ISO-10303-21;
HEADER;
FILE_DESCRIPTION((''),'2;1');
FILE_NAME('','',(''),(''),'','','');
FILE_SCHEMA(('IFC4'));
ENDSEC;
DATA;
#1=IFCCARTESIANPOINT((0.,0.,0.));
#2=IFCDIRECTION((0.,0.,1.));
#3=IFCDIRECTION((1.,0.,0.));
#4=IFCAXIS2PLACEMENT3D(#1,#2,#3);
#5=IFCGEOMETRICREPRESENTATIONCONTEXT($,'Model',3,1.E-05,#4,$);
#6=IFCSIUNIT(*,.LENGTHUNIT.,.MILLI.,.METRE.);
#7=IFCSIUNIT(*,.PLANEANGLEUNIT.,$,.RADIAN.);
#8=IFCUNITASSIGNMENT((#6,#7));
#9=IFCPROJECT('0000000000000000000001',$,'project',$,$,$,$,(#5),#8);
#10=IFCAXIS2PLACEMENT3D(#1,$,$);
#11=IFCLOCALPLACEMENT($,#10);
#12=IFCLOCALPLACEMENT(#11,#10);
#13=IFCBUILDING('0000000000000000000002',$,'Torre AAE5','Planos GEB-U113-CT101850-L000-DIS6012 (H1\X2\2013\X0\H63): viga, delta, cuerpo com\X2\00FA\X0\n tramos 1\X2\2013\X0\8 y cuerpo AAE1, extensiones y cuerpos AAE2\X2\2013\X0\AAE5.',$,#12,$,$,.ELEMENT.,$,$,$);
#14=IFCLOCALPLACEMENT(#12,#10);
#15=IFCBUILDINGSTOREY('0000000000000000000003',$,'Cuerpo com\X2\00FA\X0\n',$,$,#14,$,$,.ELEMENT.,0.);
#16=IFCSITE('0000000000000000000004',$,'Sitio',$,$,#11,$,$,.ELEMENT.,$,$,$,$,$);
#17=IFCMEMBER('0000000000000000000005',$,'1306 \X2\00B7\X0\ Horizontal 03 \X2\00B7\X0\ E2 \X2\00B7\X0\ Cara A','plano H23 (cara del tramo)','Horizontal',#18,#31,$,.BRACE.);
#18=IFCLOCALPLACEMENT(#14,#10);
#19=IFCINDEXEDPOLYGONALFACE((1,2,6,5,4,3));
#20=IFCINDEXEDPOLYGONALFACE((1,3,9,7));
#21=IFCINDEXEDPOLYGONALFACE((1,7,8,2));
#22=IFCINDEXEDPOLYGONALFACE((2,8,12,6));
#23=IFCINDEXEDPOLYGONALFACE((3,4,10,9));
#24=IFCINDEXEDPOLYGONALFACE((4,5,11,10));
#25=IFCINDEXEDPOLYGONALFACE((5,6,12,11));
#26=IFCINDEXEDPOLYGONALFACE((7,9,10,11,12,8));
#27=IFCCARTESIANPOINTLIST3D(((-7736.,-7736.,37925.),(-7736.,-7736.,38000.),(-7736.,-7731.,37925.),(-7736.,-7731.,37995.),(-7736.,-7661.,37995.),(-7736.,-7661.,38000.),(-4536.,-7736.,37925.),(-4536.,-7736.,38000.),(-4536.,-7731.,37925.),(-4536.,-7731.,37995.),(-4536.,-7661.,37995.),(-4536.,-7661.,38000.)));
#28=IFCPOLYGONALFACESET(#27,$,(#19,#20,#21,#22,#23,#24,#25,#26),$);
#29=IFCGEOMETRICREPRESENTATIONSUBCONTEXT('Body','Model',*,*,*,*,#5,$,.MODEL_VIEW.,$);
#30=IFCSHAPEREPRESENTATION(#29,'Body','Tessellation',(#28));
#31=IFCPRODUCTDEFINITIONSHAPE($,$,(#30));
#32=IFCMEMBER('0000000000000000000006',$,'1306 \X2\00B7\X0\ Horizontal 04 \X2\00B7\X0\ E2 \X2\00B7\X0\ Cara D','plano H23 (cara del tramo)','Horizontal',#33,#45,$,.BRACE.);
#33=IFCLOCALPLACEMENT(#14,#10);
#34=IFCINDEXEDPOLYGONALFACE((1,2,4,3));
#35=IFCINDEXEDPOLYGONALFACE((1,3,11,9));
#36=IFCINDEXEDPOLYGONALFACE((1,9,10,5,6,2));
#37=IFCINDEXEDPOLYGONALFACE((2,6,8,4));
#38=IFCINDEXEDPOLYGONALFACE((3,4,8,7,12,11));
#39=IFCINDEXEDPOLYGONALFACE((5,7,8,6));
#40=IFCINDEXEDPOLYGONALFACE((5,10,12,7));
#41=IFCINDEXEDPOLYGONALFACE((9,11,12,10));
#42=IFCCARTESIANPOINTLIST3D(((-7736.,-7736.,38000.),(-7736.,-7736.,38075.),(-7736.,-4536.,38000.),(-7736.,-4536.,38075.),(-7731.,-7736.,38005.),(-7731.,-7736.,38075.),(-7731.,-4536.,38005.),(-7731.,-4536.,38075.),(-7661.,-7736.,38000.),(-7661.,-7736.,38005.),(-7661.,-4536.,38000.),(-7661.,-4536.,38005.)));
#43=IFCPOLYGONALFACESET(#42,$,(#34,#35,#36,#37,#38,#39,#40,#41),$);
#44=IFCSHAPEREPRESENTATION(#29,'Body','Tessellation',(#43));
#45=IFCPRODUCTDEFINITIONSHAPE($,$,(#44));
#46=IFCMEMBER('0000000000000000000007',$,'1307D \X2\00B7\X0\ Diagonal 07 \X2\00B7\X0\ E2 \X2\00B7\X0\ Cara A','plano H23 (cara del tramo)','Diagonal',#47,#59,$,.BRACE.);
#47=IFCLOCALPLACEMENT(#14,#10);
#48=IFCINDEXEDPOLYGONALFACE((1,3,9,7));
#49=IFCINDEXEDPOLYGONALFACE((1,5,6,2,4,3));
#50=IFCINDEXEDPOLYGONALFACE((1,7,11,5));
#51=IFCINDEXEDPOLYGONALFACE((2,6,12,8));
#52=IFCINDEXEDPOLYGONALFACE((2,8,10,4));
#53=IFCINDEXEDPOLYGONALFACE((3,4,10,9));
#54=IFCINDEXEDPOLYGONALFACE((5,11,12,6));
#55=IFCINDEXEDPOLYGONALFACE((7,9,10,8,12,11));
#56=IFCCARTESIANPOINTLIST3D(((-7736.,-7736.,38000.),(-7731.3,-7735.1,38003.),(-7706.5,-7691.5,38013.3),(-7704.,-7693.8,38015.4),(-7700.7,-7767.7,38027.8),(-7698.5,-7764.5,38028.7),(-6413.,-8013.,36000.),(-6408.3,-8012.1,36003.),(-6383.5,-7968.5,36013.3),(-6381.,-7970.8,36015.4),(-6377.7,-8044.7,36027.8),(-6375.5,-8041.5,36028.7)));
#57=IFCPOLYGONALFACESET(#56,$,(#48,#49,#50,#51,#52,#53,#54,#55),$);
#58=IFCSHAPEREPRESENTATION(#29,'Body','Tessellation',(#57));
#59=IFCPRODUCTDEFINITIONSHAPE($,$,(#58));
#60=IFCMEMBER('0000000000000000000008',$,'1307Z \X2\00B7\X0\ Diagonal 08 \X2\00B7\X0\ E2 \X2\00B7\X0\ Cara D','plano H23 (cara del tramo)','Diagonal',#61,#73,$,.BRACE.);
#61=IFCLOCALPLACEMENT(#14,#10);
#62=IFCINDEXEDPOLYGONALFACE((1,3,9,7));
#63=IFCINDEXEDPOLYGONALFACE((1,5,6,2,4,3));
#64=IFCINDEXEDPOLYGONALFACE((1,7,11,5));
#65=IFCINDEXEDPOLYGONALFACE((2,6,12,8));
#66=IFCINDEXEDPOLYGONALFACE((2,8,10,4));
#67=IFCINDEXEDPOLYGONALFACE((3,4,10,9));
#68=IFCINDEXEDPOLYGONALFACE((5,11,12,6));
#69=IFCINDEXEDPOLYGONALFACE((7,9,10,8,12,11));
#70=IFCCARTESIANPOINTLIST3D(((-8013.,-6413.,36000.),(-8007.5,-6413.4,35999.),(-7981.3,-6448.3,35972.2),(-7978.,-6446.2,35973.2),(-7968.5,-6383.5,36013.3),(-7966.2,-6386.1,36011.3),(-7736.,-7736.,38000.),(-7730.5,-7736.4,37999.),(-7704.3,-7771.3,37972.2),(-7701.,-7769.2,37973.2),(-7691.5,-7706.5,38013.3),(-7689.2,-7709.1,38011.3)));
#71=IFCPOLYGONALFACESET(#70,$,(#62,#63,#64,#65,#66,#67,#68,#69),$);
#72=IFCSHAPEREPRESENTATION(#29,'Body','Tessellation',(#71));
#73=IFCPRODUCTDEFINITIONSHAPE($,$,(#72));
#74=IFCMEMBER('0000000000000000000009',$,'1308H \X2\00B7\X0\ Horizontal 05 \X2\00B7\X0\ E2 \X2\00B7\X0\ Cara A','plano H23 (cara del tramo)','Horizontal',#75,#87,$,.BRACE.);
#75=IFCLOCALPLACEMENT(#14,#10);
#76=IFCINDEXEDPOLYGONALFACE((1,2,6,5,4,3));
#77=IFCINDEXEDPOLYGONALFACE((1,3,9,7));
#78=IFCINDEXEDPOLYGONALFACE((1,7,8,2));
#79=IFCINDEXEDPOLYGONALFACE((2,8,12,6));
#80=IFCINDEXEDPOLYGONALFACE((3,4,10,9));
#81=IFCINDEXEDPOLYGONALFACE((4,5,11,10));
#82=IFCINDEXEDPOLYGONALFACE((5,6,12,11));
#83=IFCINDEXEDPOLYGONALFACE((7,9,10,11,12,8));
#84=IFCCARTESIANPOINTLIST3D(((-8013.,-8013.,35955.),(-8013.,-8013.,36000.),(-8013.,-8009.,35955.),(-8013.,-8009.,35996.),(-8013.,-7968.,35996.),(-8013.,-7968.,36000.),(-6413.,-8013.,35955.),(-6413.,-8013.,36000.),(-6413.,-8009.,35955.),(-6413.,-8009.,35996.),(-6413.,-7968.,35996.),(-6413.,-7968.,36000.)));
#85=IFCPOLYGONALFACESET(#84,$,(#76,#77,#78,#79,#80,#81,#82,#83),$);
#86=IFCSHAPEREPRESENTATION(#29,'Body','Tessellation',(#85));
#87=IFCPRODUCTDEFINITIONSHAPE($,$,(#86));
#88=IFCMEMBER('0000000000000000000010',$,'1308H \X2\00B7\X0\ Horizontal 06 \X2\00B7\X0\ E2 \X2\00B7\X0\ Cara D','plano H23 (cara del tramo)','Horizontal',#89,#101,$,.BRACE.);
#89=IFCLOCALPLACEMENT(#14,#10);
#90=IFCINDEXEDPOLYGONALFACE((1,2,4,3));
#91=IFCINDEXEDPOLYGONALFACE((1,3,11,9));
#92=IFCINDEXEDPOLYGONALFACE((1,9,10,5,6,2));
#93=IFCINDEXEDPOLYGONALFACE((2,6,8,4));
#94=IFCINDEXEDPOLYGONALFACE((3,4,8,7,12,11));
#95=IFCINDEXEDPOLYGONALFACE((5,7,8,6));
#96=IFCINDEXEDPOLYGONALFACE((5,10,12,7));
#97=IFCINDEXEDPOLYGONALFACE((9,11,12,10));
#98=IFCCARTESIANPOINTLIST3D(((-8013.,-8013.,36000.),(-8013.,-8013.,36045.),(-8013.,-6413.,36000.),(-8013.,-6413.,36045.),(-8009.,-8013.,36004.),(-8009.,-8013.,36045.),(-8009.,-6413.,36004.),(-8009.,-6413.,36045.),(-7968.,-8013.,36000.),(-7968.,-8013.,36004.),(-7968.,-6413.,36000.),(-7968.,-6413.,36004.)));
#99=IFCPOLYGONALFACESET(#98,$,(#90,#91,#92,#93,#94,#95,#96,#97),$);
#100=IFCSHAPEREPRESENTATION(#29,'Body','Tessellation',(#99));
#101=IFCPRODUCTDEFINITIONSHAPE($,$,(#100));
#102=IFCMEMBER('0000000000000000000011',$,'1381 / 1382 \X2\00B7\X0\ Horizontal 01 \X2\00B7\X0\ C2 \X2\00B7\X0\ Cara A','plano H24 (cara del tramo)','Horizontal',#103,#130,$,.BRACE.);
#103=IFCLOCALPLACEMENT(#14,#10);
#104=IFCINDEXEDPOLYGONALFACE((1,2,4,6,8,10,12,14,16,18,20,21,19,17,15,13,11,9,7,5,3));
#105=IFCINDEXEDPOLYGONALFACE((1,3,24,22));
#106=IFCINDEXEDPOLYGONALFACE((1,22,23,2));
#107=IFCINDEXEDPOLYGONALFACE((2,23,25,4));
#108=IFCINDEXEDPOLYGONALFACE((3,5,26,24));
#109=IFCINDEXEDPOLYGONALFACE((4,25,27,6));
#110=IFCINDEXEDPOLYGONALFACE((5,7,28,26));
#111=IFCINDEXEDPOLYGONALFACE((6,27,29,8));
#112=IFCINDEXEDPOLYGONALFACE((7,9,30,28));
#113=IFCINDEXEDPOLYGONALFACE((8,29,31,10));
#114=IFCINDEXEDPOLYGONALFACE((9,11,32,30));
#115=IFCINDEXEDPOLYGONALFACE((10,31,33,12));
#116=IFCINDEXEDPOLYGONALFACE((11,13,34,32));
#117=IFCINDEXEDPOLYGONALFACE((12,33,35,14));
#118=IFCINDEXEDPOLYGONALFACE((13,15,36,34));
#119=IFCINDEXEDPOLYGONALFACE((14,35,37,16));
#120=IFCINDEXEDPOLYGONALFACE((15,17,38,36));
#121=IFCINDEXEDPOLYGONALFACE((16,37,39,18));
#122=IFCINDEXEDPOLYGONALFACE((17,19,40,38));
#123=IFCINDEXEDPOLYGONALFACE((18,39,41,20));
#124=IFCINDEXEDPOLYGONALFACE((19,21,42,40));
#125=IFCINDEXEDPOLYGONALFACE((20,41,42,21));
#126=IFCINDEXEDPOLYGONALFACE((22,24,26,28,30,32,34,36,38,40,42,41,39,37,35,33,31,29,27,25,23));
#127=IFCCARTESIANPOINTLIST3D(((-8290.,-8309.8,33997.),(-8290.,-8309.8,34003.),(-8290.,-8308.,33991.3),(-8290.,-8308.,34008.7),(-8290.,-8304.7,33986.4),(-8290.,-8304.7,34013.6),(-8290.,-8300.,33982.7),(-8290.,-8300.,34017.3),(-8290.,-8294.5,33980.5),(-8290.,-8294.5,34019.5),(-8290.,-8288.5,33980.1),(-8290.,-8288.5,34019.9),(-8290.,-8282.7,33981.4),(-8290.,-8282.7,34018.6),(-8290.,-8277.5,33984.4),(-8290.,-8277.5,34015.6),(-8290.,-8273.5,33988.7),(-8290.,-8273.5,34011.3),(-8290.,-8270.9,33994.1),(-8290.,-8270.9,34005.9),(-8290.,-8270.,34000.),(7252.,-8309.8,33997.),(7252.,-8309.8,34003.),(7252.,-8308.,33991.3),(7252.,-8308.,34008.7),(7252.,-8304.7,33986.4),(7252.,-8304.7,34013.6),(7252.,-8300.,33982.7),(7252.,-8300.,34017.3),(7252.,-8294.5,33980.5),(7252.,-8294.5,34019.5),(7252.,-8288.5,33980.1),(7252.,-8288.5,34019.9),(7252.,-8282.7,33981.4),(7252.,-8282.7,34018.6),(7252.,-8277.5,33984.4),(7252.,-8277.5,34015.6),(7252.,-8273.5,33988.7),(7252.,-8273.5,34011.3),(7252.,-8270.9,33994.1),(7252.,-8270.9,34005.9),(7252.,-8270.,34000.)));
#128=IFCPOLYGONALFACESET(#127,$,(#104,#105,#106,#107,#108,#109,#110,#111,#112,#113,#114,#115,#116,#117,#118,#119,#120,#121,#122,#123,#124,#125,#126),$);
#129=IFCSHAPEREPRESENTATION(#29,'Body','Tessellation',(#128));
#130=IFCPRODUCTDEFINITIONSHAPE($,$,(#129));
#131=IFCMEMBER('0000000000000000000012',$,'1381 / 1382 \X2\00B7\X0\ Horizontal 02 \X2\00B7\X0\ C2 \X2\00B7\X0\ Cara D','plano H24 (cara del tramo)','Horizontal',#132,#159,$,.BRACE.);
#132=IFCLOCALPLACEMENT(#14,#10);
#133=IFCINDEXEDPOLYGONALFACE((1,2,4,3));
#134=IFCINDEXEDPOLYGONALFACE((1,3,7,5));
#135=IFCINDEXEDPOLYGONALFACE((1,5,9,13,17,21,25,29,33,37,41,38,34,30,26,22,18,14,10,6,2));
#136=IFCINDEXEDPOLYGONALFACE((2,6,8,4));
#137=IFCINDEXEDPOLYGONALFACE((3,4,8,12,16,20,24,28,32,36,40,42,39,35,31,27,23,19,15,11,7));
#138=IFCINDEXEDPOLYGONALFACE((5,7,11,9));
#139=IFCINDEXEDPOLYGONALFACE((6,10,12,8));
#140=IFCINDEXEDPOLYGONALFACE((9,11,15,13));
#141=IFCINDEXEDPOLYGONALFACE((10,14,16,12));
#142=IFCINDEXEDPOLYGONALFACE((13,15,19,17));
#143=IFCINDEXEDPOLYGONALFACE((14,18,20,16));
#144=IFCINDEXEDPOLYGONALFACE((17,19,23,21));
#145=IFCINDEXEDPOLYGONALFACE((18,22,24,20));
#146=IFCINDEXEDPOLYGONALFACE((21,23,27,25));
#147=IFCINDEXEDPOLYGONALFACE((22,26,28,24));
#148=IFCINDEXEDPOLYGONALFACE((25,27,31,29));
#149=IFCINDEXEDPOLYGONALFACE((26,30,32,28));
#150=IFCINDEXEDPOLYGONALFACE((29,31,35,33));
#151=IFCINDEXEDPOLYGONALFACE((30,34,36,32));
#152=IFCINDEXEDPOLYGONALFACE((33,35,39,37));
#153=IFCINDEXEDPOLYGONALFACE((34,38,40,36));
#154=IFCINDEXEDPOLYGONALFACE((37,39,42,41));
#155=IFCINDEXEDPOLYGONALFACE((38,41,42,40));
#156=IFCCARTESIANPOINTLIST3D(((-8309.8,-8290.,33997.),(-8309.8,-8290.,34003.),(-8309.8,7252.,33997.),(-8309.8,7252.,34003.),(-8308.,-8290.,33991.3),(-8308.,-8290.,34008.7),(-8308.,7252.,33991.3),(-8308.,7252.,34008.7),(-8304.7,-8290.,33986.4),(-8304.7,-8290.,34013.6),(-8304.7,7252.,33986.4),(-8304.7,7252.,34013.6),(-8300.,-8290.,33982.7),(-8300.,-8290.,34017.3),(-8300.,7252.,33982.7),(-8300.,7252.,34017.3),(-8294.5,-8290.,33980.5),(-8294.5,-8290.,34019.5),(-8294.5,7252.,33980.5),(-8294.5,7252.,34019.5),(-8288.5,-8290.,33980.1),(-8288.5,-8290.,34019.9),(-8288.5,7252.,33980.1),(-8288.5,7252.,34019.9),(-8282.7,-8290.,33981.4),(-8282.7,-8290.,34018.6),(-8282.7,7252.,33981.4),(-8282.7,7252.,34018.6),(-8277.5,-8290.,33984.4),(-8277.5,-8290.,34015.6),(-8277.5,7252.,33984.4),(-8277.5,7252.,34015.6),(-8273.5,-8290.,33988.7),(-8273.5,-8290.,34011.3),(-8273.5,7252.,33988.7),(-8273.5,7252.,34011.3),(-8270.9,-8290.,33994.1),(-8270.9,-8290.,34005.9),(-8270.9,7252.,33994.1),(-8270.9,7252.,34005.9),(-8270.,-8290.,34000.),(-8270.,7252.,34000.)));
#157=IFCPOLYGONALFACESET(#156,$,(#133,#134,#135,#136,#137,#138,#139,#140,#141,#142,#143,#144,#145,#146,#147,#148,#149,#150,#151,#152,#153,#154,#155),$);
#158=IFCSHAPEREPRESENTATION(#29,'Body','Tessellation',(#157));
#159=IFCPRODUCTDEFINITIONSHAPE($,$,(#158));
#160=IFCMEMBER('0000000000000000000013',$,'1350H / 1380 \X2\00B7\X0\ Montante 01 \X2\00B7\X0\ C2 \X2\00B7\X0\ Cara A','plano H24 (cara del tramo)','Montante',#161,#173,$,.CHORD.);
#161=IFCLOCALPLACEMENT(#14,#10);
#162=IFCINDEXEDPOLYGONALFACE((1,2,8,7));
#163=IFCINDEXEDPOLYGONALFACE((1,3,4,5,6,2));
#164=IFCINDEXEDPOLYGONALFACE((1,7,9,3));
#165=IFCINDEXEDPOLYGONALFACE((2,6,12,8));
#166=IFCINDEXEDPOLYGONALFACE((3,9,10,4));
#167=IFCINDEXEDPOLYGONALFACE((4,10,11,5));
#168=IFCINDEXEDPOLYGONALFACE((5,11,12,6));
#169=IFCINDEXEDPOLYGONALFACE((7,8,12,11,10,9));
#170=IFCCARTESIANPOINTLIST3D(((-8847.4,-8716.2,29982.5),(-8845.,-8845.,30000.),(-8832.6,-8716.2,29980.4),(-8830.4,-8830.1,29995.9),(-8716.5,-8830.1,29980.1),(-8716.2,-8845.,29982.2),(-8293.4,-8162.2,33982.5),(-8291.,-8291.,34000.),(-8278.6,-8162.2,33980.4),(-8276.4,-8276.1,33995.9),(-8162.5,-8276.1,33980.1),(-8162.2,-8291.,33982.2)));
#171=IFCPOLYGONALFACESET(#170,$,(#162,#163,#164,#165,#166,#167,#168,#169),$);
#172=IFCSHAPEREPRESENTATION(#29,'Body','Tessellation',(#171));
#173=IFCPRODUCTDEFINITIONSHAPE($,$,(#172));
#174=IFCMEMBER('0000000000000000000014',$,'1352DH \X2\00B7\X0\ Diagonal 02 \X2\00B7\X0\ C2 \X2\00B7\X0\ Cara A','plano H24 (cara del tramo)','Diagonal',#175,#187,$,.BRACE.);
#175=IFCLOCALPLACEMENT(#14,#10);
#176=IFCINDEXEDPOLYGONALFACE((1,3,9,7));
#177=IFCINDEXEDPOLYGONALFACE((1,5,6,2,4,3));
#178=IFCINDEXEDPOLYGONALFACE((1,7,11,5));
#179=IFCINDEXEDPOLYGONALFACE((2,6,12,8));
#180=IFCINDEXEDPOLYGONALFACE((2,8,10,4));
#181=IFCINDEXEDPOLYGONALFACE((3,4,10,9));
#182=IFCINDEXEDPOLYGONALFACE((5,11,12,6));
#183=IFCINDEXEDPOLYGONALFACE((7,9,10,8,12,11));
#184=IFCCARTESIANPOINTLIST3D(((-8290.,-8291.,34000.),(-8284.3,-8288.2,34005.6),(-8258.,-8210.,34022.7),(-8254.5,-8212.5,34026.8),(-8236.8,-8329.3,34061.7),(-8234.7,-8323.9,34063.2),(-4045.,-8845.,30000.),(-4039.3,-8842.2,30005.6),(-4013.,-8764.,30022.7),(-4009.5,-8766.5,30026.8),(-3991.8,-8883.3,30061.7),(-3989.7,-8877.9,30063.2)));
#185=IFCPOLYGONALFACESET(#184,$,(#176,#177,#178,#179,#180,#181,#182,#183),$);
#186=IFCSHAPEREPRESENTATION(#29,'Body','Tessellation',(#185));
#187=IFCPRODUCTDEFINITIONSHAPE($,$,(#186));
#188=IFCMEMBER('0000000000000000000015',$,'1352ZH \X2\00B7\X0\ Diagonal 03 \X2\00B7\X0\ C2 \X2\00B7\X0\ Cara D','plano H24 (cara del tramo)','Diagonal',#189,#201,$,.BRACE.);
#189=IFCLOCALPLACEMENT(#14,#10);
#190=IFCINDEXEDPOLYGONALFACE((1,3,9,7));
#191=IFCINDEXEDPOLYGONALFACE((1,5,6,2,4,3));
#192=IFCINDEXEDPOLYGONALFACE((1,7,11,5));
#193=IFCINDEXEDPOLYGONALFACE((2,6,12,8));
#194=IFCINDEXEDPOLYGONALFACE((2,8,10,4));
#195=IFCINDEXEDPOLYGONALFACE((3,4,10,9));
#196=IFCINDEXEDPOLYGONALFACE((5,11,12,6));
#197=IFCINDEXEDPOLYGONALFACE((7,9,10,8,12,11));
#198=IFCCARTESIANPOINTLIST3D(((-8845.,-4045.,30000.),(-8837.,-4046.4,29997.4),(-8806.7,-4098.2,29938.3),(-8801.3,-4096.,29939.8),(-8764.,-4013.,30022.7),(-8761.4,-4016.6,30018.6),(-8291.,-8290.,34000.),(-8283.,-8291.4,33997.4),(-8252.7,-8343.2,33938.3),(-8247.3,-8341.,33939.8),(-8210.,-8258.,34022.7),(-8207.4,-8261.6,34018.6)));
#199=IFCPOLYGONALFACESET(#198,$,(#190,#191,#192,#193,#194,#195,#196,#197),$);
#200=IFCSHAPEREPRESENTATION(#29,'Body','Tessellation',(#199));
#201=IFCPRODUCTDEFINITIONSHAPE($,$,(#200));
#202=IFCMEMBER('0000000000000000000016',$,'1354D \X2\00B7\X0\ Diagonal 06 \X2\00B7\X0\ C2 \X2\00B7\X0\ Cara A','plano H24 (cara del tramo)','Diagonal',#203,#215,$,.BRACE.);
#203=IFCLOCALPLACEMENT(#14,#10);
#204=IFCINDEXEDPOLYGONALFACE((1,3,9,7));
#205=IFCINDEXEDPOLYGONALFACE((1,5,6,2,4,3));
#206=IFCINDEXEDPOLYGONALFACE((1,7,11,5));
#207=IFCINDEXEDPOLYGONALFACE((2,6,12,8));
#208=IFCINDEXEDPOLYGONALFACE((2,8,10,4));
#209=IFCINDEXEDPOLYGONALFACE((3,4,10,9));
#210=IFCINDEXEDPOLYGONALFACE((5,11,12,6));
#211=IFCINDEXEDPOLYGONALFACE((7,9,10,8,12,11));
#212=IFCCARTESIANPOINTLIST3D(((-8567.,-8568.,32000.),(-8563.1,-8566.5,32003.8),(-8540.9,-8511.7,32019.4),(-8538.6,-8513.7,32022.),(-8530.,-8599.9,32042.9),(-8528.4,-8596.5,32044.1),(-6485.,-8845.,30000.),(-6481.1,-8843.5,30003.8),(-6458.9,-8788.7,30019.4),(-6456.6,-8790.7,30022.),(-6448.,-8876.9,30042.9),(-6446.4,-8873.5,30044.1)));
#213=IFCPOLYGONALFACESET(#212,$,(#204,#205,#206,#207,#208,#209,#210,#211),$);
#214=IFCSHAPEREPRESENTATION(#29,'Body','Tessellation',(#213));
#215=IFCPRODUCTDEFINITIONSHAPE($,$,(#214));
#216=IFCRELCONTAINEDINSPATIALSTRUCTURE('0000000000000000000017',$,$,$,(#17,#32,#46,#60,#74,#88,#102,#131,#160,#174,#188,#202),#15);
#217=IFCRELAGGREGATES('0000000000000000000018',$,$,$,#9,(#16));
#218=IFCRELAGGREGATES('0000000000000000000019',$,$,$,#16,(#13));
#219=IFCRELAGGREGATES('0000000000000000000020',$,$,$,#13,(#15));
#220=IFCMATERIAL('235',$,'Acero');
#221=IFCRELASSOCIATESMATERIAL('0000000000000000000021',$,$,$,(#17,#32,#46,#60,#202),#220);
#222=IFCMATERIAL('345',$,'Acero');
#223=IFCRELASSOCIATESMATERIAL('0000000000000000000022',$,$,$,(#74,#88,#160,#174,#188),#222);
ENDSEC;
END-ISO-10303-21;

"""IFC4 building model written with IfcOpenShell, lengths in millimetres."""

from ifc_helpers import new_model, si_unit, frame, frame_2d, origin, origin_with_axes, place, context, subcontext, project, spatial, circle, l_section, extrude, material, element, save


model = new_model("IFC4")

# Units and contexts
model_context = context("Model", 3, precision=1e-05, world=origin_with_axes())
body_context = subcontext(model_context, "Body", "Model", "MODEL_VIEW")
ifc_project = project(units=[si_unit("LENGTHUNIT", "METRE", prefix="MILLI"), si_unit("PLANEANGLEUNIT", "RADIAN")], contexts=[model_context])

# Site, building, storey
site_placement = place(None, origin())
site = spatial("IfcSite", under=ifc_project, at=site_placement, Name="Sitio", CompositionType="ELEMENT")
building_placement = place(site_placement, origin())
building = spatial("IfcBuilding", under=site, at=building_placement, Name="Torre AAE5", Description="Planos GEB-U113-CT101850-L000-DIS6012 (H1–H63): viga, delta, cuerpo común tramos 1–8 y cuerpo AAE1, extensiones y cuerpos AAE2–AAE5.", CompositionType="ELEMENT")
storey_placement = place(building_placement, origin())
storey = spatial("IfcBuildingStorey", under=building, at=storey_placement, Name="Cuerpo común", CompositionType="ELEMENT", Elevation=0.0)

# Members
ifc_material_1 = material(Name="235", Category="Acero")
for number, where, z_axis, x_axis, name in (
    (1, (-4536.0, -7736.0, 38000.0), (-1.0, 0.0, 0.0), (0.0, 1.0, 0.0), "1306 · Horizontal 03 · E2 · Cara A"),
    (2, (-7736.0, -4536.0, 38000.0), (0.0, -1.0, 0.0), (1.0, 0.0, 0.0), "1306 · Horizontal 04 · E2 · Cara D"),
):
    element("IfcMember", number, at=place(storey_placement, frame(where, z_axis=z_axis, x_axis=x_axis)), inside=storey, material=ifc_material_1, Name=name, Description="plano H23 (cara del tramo)", ObjectType="Horizontal", PredefinedType="BRACE", context=body_context, shape_type="SweptSolid", body=[
        extrude(l_section(Depth=75.0, Width=75.0, Thickness=5.0, at=frame_2d((37.5, 37.5))), None, (0.0, 0.0, 1.0), 3200.0),
    ])
for number, where, z_axis, x_axis, name in (
    (3, (-7736.0, -7736.0, 38000.0), (0.548069, -0.114751, -0.828524), (0.535928, 0.808683, 0.242514), "1307D · Diagonal 07 · E2 · Cara A"),
    (4, (-7736.0, -7736.0, 38000.0), (-0.114751, 0.548069, -0.828524), (0.808683, 0.535928, 0.242514), "1307Z · Diagonal 08 · E2 · Cara D"),
):
    element("IfcMember", number, at=place(storey_placement, frame(where, z_axis=z_axis, x_axis=x_axis)), inside=storey, material=ifc_material_1, Name=name, Description="plano H23 (cara del tramo)", ObjectType="Diagonal", PredefinedType="BRACE", context=body_context, shape_type="SweptSolid", body=[
        extrude(l_section(Depth=55.0, Width=55.0, Thickness=4.0, at=frame_2d((27.5, 27.5))), None, (0.0, 0.0, 1.0), 2413.9),
    ])
ifc_material_2 = material(Name="345", Category="Acero")
for number, where, z_axis, x_axis, name in (
    (5, (-6413.0, -8013.0, 36000.0), (-1.0, 0.0, 0.0), (0.0, 1.0, 0.0), "1308H · Horizontal 05 · E2 · Cara A"),
    (6, (-8013.0, -6413.0, 36000.0), (0.0, -1.0, 0.0), (1.0, 0.0, 0.0), "1308H · Horizontal 06 · E2 · Cara D"),
):
    element("IfcMember", number, at=place(storey_placement, frame(where, z_axis=z_axis, x_axis=x_axis)), inside=storey, material=ifc_material_2, Name=name, Description="plano H23 (cara del tramo)", ObjectType="Horizontal", PredefinedType="BRACE", context=body_context, shape_type="SweptSolid", body=[
        extrude(l_section(Depth=45.0, Width=45.0, Thickness=4.0, at=frame_2d((22.5, 22.5))), None, (0.0, 0.0, 1.0), 1600.0),
    ])
for number, where, z_axis, x_axis, name in (
    (7, (-8290.0, -8290.0, 34000.0), (1.0, 0.0, 0.0), (0.0, 1.0, 0.0), "1381 / 1382 · Horizontal 01 · C2 · Cara A"),
    (8, (-8290.0, -8290.0, 34000.0), (0.0, 1.0, 0.0), (1.0, 0.0, 0.0), "1381 / 1382 · Horizontal 02 · C2 · Cara D"),
):
    element("IfcMember", number, at=place(storey_placement, frame(where, z_axis=z_axis, x_axis=x_axis)), inside=storey, Name=name, Description="plano H24 (cara del tramo)", ObjectType="Horizontal", PredefinedType="BRACE", context=body_context, shape_type="SweptSolid", body=[
        extrude(circle(Radius=20.0), None, (0.0, 0.0, 1.0), 15542.0),
    ])
member_1_placement = place(storey_placement, frame((-8291.0, -8291.0, 34000.0), z_axis=(-0.135917, -0.135917, -0.981353), x_axis=(-0.018647, 0.99072, -0.134632)))
element("IfcMember", 9, at=member_1_placement, inside=storey, material=ifc_material_2, Name="1350H / 1380 · Montante 01 · C2 · Cara A", Description="plano H24 (cara del tramo)", ObjectType="Montante", PredefinedType="CHORD", context=body_context, shape_type="SweptSolid", body=[
    extrude(l_section(Depth=130.0, Width=130.0, Thickness=15.0, at=frame_2d((65.0, 65.0))), None, (0.0, 0.0, 1.0), 4076.0),
])
for number, where, z_axis, x_axis, name in (
    (10, (-8290.0, -8291.0, 34000.0), (0.724536, -0.094557, -0.68272), (0.355138, 0.900146, 0.25222), "1352DH · Diagonal 02 · C2 · Cara A"),
    (11, (-8291.0, -8290.0, 34000.0), (-0.094557, 0.724536, -0.68272), (0.900146, 0.355138, 0.25222), "1352ZH · Diagonal 03 · C2 · Cara D"),
):
    element("IfcMember", number, at=place(storey_placement, frame(where, z_axis=z_axis, x_axis=x_axis)), inside=storey, material=ifc_material_2, Name=name, Description="plano H24 (cara del tramo)", ObjectType="Diagonal", PredefinedType="BRACE", context=body_context, shape_type="SweptSolid", body=[
        extrude(l_section(Depth=90.0, Width=90.0, Thickness=6.0, at=frame_2d((45.0, 45.0))), None, (0.0, 0.0, 1.0), 5858.9),
    ])
for number, where, z_axis, x_axis, name in (
    (12, (-8567.0, -8568.0, 32000.0), (0.717869, -0.095509, -0.689596), (0.401881, 0.865687, 0.29846), "1354D · Diagonal 06 · C2 · Cara A"),
):
    element("IfcMember", number, at=place(storey_placement, frame(where, z_axis=z_axis, x_axis=x_axis)), inside=storey, material=ifc_material_1, Name=name, Description="plano H24 (cara del tramo)", ObjectType="Diagonal", PredefinedType="BRACE", context=body_context, shape_type="SweptSolid", body=[
        extrude(l_section(Depth=65.0, Width=65.0, Thickness=4.0, at=frame_2d((32.5, 32.5))), None, (0.0, 0.0, 1.0), 2900.3),
    ])

save(model, "model.ifc")
